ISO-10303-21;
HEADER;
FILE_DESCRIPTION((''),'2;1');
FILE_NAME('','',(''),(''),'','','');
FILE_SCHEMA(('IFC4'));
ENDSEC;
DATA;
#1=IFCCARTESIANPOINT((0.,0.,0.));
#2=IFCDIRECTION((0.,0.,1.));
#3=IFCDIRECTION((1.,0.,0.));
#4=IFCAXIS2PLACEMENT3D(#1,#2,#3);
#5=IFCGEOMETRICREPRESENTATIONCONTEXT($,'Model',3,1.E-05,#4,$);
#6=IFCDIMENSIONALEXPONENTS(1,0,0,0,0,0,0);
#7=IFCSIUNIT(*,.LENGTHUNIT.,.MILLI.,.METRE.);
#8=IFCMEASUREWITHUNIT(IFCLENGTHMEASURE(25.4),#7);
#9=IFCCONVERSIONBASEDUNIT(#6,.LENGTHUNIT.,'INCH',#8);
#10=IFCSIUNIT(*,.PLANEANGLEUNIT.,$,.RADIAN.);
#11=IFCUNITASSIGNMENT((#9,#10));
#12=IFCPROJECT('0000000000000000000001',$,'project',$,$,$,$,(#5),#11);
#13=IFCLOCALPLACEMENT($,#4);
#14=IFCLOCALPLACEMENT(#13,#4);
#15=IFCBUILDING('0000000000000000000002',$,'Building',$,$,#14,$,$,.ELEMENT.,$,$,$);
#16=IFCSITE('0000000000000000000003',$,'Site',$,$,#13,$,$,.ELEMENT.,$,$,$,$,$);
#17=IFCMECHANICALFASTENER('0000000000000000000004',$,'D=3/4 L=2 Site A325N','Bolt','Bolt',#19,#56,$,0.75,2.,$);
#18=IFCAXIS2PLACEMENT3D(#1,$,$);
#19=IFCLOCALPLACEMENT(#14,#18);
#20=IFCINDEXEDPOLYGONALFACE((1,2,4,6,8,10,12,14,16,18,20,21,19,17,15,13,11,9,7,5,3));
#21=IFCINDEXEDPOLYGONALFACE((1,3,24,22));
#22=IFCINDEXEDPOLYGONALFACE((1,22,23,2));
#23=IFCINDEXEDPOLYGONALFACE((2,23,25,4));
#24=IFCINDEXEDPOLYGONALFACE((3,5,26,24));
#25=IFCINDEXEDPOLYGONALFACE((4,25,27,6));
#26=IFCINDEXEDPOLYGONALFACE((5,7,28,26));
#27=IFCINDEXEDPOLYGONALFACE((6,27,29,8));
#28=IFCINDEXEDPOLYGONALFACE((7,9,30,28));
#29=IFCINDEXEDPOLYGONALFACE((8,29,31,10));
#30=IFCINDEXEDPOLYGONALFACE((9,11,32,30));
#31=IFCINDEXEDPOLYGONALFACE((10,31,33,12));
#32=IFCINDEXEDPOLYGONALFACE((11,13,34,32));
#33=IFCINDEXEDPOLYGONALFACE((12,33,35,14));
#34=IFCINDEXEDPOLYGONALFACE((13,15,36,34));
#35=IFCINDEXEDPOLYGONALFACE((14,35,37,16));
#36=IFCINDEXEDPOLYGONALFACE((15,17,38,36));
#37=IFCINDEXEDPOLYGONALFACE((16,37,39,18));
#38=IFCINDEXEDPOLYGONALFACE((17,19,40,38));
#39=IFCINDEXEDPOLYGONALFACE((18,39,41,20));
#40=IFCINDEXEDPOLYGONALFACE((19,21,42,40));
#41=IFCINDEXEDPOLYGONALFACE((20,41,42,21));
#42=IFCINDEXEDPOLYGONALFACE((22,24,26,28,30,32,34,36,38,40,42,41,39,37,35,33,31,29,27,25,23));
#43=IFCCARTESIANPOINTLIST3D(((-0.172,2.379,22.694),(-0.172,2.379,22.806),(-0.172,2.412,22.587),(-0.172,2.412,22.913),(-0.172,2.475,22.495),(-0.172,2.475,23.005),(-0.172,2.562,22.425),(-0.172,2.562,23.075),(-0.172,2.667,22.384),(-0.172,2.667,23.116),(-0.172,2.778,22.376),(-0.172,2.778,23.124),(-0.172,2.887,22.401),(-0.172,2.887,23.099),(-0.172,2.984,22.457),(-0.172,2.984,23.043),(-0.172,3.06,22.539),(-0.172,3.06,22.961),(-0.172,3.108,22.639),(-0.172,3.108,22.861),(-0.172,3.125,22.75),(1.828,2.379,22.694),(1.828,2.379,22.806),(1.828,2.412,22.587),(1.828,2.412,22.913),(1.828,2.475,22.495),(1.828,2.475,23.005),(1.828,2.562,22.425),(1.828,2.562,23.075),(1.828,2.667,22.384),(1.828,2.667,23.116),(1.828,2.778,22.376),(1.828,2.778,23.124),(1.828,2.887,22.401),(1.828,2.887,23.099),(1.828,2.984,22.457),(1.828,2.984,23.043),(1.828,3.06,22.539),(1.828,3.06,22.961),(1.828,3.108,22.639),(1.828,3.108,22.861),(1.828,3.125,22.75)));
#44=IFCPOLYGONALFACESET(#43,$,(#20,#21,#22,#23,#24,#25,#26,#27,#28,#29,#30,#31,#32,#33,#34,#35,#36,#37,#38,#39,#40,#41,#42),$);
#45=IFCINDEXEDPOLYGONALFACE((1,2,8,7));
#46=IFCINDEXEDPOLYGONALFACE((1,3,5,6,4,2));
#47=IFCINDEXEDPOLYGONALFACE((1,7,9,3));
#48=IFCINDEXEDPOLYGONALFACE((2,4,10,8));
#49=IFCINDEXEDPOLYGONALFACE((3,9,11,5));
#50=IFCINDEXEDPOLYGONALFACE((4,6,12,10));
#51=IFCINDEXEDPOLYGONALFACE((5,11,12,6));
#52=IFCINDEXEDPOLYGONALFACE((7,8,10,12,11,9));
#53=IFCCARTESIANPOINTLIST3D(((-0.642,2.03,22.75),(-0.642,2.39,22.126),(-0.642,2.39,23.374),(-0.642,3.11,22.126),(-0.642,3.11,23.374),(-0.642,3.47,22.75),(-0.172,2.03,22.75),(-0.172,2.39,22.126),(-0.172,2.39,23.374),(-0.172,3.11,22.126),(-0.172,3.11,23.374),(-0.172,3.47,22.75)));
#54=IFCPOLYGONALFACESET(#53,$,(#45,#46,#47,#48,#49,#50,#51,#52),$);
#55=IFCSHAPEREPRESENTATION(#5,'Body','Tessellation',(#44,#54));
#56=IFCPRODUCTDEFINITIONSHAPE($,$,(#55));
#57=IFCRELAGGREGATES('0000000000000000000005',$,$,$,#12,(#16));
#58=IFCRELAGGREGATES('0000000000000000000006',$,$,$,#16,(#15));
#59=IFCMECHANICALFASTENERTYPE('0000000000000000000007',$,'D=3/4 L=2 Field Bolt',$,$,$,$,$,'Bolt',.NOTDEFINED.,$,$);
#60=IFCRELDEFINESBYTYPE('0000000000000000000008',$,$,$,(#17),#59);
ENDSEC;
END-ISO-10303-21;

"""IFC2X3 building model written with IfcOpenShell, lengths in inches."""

from ifc_helpers import new_model, entity, si_unit, converted_unit, frame, origin_with_axes, origin_2d_with_axis, place, context, project, spatial, polyline, circle, outline, extrude, source, transform, mapped, type_object, type_shapes, element, save


model = new_model("IFC2X3")

# Units and contexts
model_context = context("Model", 3, precision=1e-05, world=origin_with_axes())
ifc_project = project(units=[converted_unit("LENGTHUNIT", "INCH", entity("IfcLengthMeasure", 25.4), si_unit("LENGTHUNIT", "METRE", prefix="MILLI"), dimensions=[1, 0, 0, 0, 0, 0, 0]), si_unit("PLANEANGLEUNIT", "RADIAN")], contexts=[model_context])

# Site, building
site_placement = place(None, origin_with_axes())
site = spatial("IfcSite", under=ifc_project, at=site_placement, Name="Site", CompositionType="ELEMENT")
building_placement = place(site_placement, origin_with_axes())
building = spatial("IfcBuilding", under=site, at=building_placement, Name="Building", CompositionType="ELEMENT")

# Shared definitions
assembly_1_placement = place(building_placement, frame((0.0, 0.0, 21.0), z_axis=(0.0, -1.0, 0.0), x_axis=(0.0, 0.0, 1.0)))

# Mechanical fastener
mechanical_fastener_type_1 = type_object("IfcMechanicalFastenerType", Name="D=3/4 L=2 Field Bolt", ElementType="Bolt")
shared_shape_1 = source(origin_with_axes(), model_context, "Body", "SweptSolid", [
    extrude(circle(Radius=0.375, at=origin_2d_with_axis()), frame((0.0, 0.0, 0.0), z_axis=(1.0, 0.0, 0.0), x_axis=(0.0, 1.0, 0.0)), (0.0, 0.0, 1.0), 2.0),
    extrude(outline(polyline([(-0.72, 0.0), (-0.36, 0.624), (0.36, 0.624), (0.72, 0.0), (0.36, -0.624), (-0.36, -0.624), (-0.72, 0.0)])), frame((0.0, 0.0, 0.0), z_axis=(1.0, 0.0, 0.0), x_axis=(0.0, 1.0, 0.0)), (0.0, 0.0, -1.0), 0.47),
])
type_shapes(mechanical_fastener_type_1, [shared_shape_1])
placement_1 = place(assembly_1_placement, frame((1.75, 0.172, -2.75), z_axis=(1.0, 0.0, 0.0), x_axis=(0.0, -1.0, 0.0)))
mechanical_fastener_1_placement = place(placement_1, origin_with_axes())
element("IfcMechanicalFastener", 1, at=mechanical_fastener_1_placement, type_object=mechanical_fastener_type_1, Name="D=3/4 L=2 Site A325N", Description="Bolt", ObjectType="Bolt", NominalDiameter=0.75, NominalLength=2.0, context=model_context, shape_type="MappedRepresentation", body=[
    mapped(shared_shape_1, transform((0.0, 0.0, 0.0), scale=1.0)),
])

save(model, "model.ifc")
